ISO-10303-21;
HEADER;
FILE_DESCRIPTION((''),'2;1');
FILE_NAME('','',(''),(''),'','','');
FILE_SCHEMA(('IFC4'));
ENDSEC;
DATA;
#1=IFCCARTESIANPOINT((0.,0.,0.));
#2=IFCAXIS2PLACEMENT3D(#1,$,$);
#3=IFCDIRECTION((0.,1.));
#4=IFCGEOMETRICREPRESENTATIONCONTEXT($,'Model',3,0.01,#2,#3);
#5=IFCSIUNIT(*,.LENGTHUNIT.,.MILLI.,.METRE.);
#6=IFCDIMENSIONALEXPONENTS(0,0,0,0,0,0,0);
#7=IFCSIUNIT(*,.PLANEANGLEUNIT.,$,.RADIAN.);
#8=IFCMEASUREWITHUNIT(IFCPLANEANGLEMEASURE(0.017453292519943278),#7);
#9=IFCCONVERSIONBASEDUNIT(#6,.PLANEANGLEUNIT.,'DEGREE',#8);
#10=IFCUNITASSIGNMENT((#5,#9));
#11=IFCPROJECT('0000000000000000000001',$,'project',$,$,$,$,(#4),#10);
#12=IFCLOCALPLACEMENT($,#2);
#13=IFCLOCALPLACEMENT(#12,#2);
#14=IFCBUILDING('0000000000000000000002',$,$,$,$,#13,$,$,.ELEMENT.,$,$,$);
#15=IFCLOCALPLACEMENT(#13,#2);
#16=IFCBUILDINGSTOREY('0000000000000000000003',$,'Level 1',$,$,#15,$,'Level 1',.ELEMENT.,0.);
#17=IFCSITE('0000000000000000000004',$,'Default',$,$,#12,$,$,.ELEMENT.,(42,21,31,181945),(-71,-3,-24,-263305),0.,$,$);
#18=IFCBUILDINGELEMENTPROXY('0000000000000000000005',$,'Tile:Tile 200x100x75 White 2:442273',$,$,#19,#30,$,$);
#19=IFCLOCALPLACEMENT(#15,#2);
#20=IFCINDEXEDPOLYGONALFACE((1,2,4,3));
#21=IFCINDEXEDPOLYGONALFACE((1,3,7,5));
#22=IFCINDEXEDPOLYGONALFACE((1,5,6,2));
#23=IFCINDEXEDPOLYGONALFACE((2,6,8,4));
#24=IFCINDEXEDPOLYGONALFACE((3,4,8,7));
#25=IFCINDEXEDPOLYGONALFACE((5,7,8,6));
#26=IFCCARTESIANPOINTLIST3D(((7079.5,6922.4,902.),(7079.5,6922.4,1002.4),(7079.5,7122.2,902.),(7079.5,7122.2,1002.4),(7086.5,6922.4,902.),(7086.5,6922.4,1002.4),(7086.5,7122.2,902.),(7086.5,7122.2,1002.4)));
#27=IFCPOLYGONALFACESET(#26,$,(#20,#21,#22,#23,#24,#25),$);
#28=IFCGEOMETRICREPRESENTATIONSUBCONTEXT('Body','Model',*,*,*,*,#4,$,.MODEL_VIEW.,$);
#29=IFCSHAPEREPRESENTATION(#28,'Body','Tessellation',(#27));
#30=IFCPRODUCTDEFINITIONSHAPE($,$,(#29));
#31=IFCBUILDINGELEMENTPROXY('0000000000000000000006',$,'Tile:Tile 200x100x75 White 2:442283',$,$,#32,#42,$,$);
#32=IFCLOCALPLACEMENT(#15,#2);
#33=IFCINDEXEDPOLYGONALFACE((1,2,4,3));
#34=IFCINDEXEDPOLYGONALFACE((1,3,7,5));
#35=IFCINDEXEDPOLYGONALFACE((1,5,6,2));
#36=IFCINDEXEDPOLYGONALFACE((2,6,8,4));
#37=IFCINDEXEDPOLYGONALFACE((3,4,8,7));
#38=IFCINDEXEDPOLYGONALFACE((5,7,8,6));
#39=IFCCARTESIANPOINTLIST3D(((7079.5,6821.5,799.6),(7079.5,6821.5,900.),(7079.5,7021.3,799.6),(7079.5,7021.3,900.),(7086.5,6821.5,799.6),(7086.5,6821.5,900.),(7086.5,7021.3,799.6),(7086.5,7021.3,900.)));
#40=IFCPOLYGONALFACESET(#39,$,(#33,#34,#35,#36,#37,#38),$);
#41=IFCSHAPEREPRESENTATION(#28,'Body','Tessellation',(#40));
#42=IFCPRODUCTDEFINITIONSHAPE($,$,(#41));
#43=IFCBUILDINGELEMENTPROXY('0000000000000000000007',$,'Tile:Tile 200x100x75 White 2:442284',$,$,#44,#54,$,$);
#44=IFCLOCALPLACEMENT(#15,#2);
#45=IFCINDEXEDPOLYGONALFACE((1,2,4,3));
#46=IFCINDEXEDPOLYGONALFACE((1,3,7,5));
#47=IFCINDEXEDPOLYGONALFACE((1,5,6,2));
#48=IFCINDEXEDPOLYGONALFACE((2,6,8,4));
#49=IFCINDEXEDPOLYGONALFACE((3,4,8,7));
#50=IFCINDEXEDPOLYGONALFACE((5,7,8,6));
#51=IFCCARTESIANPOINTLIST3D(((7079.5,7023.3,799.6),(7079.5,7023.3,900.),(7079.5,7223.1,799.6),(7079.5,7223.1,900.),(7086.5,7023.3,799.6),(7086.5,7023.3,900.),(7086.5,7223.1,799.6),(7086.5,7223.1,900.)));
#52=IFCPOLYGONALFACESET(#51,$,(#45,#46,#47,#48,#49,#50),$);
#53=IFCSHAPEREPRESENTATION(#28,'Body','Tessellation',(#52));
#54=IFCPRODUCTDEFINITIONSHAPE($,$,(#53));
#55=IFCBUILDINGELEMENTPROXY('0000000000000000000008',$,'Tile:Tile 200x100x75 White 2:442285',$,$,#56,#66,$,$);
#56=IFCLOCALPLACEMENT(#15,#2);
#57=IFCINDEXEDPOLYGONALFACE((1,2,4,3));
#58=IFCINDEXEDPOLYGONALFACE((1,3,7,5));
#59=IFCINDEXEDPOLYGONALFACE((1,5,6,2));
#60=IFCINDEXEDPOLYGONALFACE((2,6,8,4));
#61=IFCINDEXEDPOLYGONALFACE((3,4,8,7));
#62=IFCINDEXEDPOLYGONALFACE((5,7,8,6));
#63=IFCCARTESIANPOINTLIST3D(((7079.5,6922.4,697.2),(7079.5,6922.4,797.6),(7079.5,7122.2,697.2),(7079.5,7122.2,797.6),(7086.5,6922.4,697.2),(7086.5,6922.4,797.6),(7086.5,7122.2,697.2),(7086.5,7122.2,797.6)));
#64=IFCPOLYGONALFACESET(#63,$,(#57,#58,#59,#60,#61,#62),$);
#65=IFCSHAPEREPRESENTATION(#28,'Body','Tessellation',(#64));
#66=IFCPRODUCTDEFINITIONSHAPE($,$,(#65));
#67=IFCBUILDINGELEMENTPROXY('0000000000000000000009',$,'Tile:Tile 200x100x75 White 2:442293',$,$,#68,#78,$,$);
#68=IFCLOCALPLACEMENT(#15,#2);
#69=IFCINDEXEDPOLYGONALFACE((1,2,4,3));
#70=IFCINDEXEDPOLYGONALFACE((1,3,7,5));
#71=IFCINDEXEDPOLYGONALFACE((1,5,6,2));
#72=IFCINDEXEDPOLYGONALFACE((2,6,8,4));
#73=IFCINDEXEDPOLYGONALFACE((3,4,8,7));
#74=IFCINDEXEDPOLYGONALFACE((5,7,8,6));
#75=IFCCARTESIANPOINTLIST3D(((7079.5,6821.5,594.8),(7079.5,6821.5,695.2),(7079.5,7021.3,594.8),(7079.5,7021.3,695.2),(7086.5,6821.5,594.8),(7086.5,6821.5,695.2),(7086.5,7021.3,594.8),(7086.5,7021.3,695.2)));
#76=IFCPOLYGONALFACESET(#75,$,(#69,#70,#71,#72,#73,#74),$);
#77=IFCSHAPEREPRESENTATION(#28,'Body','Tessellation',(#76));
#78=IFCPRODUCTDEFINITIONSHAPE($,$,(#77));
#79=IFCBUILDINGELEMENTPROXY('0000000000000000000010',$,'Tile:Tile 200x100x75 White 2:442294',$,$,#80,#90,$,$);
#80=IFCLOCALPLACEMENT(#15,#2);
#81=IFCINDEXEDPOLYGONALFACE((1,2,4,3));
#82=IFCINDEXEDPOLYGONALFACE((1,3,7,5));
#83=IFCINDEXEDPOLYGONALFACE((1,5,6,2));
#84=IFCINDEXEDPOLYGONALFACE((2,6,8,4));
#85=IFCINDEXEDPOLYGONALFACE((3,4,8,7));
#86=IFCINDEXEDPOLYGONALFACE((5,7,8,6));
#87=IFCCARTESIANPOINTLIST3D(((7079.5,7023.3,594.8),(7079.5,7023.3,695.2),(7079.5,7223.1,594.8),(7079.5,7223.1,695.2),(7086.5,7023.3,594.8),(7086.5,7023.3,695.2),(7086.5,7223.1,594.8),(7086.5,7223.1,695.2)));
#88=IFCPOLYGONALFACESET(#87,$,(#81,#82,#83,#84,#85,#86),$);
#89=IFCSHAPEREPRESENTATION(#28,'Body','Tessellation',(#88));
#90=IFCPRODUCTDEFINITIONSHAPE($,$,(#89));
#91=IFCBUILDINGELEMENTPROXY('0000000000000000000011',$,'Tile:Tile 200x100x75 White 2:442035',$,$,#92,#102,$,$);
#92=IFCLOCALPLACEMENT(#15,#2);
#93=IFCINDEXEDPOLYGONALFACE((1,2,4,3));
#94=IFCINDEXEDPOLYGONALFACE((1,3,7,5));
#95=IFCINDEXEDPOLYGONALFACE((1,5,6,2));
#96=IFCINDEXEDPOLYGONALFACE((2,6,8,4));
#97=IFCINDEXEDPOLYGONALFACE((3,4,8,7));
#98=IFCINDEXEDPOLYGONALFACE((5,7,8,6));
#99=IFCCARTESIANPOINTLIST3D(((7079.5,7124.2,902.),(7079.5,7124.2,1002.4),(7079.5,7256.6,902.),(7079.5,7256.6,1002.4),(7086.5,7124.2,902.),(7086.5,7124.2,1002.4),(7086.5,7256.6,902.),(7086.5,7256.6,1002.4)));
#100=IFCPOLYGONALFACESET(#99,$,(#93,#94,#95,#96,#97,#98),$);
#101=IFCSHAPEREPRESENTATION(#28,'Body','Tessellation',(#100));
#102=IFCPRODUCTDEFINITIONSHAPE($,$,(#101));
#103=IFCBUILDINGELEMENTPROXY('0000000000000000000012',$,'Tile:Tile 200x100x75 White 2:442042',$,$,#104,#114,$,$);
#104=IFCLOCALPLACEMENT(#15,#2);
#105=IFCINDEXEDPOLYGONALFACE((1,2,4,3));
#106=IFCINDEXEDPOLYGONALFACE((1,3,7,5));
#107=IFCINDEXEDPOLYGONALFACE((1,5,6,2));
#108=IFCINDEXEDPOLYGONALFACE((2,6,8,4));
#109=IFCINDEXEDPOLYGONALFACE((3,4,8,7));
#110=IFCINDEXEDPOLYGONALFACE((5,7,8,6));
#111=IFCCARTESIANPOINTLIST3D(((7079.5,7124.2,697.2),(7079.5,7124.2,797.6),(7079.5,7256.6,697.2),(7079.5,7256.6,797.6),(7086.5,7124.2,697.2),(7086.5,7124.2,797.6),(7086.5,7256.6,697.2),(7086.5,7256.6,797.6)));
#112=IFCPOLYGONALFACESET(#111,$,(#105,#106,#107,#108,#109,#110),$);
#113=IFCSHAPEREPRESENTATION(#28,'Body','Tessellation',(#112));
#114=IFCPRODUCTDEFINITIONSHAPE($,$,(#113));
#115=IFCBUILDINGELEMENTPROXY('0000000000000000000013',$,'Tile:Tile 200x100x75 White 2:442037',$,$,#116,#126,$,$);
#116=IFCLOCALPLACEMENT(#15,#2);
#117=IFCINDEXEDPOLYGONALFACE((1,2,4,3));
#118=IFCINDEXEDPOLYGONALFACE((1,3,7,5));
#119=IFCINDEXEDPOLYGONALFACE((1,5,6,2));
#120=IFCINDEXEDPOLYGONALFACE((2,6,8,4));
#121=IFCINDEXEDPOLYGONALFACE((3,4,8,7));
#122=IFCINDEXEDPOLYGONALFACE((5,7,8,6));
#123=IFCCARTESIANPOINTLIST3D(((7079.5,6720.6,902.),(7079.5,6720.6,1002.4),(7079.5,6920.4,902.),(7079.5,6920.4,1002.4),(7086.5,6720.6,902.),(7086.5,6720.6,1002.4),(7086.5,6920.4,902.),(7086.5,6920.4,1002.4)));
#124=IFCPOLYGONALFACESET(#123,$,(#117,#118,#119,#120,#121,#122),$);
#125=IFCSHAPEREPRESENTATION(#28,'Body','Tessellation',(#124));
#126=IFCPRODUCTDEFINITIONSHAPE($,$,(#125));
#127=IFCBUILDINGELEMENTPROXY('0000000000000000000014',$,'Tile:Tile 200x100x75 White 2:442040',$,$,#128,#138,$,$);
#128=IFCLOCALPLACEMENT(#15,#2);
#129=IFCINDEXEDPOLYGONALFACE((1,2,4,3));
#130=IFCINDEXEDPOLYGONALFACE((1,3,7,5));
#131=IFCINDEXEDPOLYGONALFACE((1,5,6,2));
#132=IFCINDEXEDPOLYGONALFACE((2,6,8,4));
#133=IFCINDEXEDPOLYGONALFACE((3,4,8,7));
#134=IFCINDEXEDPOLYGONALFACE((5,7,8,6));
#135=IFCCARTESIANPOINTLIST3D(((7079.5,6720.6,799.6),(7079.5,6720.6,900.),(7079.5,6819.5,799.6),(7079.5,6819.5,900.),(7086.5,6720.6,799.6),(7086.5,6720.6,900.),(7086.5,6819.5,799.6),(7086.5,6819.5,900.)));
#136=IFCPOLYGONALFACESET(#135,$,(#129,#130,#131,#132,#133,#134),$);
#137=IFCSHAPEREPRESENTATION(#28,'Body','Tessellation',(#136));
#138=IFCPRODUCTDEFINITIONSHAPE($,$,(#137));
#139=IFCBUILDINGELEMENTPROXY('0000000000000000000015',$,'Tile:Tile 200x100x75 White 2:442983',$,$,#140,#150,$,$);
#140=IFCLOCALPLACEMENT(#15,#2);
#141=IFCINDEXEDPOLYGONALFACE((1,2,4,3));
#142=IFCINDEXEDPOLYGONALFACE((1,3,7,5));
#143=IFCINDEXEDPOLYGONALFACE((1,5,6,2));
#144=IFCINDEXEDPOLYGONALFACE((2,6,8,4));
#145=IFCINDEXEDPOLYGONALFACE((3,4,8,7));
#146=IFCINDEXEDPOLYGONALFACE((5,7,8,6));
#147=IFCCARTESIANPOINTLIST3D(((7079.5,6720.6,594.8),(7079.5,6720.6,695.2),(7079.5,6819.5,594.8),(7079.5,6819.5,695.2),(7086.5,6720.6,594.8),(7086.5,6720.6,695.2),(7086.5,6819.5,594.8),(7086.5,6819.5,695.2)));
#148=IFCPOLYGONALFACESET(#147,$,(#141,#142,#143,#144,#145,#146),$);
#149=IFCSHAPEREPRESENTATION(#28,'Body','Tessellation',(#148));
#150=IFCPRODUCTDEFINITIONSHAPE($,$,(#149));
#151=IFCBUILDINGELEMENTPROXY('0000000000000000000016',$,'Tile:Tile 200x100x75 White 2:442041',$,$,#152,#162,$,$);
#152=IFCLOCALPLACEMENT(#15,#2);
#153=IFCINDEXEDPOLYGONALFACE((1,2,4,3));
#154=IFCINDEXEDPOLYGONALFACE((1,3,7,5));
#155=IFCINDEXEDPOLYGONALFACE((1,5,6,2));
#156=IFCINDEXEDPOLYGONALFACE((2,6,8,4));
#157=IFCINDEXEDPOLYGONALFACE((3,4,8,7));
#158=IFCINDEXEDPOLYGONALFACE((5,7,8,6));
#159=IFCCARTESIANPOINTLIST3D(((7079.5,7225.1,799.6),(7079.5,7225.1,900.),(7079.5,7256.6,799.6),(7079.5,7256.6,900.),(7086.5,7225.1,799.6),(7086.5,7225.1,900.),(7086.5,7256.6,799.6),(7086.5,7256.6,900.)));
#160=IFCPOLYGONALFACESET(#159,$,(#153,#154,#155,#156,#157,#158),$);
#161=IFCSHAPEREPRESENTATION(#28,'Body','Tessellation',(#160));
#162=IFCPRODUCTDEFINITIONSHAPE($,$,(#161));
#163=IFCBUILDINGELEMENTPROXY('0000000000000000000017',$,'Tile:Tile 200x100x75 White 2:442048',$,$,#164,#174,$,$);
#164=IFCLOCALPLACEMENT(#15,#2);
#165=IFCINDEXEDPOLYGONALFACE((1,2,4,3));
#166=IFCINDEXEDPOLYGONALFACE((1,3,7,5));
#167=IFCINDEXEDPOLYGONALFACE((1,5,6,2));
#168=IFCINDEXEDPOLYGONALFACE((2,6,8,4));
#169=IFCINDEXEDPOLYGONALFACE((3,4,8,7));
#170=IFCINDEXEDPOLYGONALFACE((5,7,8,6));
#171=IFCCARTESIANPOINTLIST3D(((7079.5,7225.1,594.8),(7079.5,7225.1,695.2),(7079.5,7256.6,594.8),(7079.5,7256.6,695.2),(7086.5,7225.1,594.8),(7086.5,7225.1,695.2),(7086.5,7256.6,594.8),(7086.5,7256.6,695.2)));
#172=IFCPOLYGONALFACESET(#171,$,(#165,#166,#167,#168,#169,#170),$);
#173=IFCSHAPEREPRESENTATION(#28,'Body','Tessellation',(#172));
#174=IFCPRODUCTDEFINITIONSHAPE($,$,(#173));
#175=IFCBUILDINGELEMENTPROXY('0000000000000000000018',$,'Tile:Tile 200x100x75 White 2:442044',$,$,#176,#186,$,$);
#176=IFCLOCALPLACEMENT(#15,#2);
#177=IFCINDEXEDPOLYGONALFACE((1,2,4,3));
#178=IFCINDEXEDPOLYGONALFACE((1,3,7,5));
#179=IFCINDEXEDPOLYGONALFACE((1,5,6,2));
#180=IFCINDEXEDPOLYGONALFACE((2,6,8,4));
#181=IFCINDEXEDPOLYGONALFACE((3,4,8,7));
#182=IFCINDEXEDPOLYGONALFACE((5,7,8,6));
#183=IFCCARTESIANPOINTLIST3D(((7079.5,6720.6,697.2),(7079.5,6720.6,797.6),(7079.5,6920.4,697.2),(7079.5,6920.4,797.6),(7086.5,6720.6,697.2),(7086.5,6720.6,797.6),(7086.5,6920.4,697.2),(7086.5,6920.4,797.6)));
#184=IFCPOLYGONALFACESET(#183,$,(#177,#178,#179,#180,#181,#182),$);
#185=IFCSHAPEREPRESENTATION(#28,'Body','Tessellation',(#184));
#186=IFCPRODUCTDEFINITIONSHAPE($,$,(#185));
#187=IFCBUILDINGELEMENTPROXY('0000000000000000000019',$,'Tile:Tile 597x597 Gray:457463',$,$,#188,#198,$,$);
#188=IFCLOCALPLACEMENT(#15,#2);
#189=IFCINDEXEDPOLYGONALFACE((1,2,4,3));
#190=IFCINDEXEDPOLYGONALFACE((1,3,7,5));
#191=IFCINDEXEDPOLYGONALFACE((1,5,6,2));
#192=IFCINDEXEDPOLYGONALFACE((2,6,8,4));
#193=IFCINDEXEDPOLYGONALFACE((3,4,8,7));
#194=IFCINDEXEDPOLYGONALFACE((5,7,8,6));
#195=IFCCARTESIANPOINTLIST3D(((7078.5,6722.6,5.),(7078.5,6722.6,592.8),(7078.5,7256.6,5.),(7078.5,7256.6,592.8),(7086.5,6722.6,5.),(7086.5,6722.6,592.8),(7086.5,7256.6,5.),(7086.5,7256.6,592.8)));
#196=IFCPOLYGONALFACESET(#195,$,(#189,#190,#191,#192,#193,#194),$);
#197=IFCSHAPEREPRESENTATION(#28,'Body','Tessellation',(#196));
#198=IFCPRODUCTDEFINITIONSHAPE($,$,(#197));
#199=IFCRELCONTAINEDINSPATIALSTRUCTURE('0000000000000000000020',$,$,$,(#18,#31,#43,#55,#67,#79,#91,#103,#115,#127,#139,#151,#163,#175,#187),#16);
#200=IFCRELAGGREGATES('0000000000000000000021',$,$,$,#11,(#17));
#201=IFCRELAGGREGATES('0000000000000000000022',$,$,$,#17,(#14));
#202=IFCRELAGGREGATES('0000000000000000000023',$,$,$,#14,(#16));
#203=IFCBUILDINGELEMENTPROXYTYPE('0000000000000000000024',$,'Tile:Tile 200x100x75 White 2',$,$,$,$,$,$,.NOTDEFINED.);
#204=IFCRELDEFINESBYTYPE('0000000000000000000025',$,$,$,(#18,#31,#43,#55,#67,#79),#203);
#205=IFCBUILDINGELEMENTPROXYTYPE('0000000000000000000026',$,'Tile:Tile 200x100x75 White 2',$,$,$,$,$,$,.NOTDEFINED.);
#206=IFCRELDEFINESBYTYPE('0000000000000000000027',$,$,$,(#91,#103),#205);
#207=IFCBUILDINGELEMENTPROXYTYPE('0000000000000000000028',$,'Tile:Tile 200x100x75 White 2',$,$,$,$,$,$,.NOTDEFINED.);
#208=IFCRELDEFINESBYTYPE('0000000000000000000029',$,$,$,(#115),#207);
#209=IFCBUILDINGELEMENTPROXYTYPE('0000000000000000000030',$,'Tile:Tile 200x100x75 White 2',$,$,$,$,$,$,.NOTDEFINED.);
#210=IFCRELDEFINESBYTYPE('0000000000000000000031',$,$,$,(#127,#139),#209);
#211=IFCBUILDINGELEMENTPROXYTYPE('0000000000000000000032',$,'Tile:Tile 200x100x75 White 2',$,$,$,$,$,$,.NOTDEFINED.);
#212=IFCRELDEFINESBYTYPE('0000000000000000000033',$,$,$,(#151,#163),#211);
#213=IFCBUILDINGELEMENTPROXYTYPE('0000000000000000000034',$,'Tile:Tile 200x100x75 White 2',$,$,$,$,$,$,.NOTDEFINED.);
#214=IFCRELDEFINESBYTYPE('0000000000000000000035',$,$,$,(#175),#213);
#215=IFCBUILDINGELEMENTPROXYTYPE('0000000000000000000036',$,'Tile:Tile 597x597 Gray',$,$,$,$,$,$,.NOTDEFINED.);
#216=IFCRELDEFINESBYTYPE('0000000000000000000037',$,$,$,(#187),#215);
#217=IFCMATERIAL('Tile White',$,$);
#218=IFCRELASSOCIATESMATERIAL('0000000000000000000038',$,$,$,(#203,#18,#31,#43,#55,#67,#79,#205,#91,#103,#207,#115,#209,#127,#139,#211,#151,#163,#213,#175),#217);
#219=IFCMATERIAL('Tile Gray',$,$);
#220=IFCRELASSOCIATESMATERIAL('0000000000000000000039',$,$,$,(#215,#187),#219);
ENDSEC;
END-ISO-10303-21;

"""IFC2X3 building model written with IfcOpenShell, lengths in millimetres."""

from ifc_helpers import new_model, entity, si_unit, converted_unit, direction, frame, frame_2d, origin, origin_2d_with_axis, place, context, subcontext, project, spatial, rectangle, extrude, source, transform, mapped, material, type_object, type_shapes, element, save


model = new_model("IFC2X3")

# Units and contexts
model_context = context("Model", 3, precision=0.01, world=origin(), true_north=direction((0.0, 1.0)))
body_context = subcontext(model_context, "Body", "Model", "MODEL_VIEW")
ifc_project = project(units=[si_unit("LENGTHUNIT", "METRE", prefix="MILLI"), converted_unit("PLANEANGLEUNIT", "DEGREE", entity("IfcPlaneAngleMeasure", 0.017453292519943278), si_unit("PLANEANGLEUNIT", "RADIAN"), dimensions=[0, 0, 0, 0, 0, 0, 0])], contexts=[model_context])

# Site, building, storey
site_placement = place(None, origin())
site = spatial("IfcSite", under=ifc_project, at=site_placement, Name="Default", CompositionType="ELEMENT", RefLatitude=(42, 21, 31, 181945), RefLongitude=(-71, -3, -24, -263305), RefElevation=0.0)
building_placement = place(site_placement, origin())
building = spatial("IfcBuilding", under=site, at=building_placement, CompositionType="ELEMENT")
storey_placement = place(building_placement, origin())
storey = spatial("IfcBuildingStorey", under=building, at=storey_placement, Name="Level 1", LongName="Level 1", CompositionType="ELEMENT", Elevation=0.0)

# Building element proxies
ifc_material_1 = material(Name="Tile White")
building_element_proxy_type_1 = type_object("IfcBuildingElementProxyType", Name="Tile:Tile 200x100x75 White 2", PredefinedType="NOTDEFINED", material=ifc_material_1)
shared_shape_1 = source(origin(), body_context, "Body", "SweptSolid", [
    extrude(rectangle(XDim=199.8, YDim=100.4, at=frame_2d((0.0, 0.0), x_axis=(1.0, 0.0))), frame((-50.2, -99.9, 0.0), z_axis=(0.0, 0.0, 1.0), x_axis=(0.0, -1.0, 0.0)), (0.0, 0.0, 1.0), 7.0),
])
type_shapes(building_element_proxy_type_1, [shared_shape_1])
for number, where, z_axis, x_axis, name in (
    (1, (7086.5, 7122.2, 1002.4), (-1.0, 0.0, 0.0), (0.0, 0.0, 1.0), "Tile:Tile 200x100x75 White 2:442273"),
    (2, (7086.5, 7021.3, 900.0), (-1.0, 0.0, 0.0), (0.0, 0.0, 1.0), "Tile:Tile 200x100x75 White 2:442283"),
    (3, (7086.5, 7223.1, 900.0), (-1.0, 0.0, 0.0), (0.0, 0.0, 1.0), "Tile:Tile 200x100x75 White 2:442284"),
    (4, (7086.5, 7122.2, 797.6), (-1.0, 0.0, 0.0), (0.0, 0.0, 1.0), "Tile:Tile 200x100x75 White 2:442285"),
    (5, (7086.5, 7021.3, 695.2), (-1.0, 0.0, 0.0), (0.0, 0.0, 1.0), "Tile:Tile 200x100x75 White 2:442293"),
    (6, (7086.5, 7223.1, 695.2), (-1.0, 0.0, 0.0), (0.0, 0.0, 1.0), "Tile:Tile 200x100x75 White 2:442294"),
):
    element("IfcBuildingElementProxy", number, at=place(storey_placement, frame(where, z_axis=z_axis, x_axis=x_axis)), inside=storey, type_object=building_element_proxy_type_1, material=ifc_material_1, Name=name, context=body_context, shape_type="MappedRepresentation", body=[
        mapped(shared_shape_1, transform((0.0, 0.0, 0.0), scale=1.0)),
    ])
building_element_proxy_type_2 = type_object("IfcBuildingElementProxyType", Name="Tile:Tile 200x100x75 White 2", PredefinedType="NOTDEFINED", material=ifc_material_1)
shared_shape_2 = source(origin(), body_context, "Body", "SweptSolid", [
    extrude(rectangle(XDim=100.4, YDim=132.4, at=frame_2d((0.0, 0.0), x_axis=(1.0, 0.0))), frame((-50.2, 66.2, 0.0)), (0.0, 0.0, 1.0), 7.0),
])
type_shapes(building_element_proxy_type_2, [shared_shape_2])
for number, where, z_axis, x_axis, name in (
    (7, (7086.5, 7124.2, 1002.4), (-1.0, 0.0, 0.0), (0.0, 0.0, 1.0), "Tile:Tile 200x100x75 White 2:442035"),
    (8, (7086.5, 7124.2, 797.6), (-1.0, 0.0, 0.0), (0.0, 0.0, 1.0), "Tile:Tile 200x100x75 White 2:442042"),
):
    element("IfcBuildingElementProxy", number, at=place(storey_placement, frame(where, z_axis=z_axis, x_axis=x_axis)), inside=storey, type_object=building_element_proxy_type_2, material=ifc_material_1, Name=name, context=body_context, shape_type="MappedRepresentation", body=[
        mapped(shared_shape_2, transform((0.0, 0.0, 0.0), scale=1.0)),
    ])
building_element_proxy_type_3 = type_object("IfcBuildingElementProxyType", Name="Tile:Tile 200x100x75 White 2", PredefinedType="NOTDEFINED", material=ifc_material_1)
shared_shape_3 = source(origin(), body_context, "Body", "SweptSolid", [
    extrude(rectangle(XDim=100.4, YDim=199.8, at=origin_2d_with_axis()), frame((-50.2, 99.9, 0.0)), (0.0, 0.0, 1.0), 7.0),
])
type_shapes(building_element_proxy_type_3, [shared_shape_3])
proxy_1_placement = place(storey_placement, frame((7086.5, 6720.6, 1002.4), z_axis=(-1.0, 0.0, 0.0), x_axis=(0.0, 0.0, 1.0)))
element("IfcBuildingElementProxy", 9, at=proxy_1_placement, inside=storey, type_object=building_element_proxy_type_3, material=ifc_material_1, Name="Tile:Tile 200x100x75 White 2:442037", context=body_context, shape_type="MappedRepresentation", body=[
    mapped(shared_shape_3, transform((0.0, 0.0, 0.0), scale=1.0)),
])
building_element_proxy_type_4 = type_object("IfcBuildingElementProxyType", Name="Tile:Tile 200x100x75 White 2", PredefinedType="NOTDEFINED", material=ifc_material_1)
shared_shape_4 = source(origin(), body_context, "Body", "SweptSolid", [
    extrude(rectangle(XDim=100.4, YDim=98.9, at=origin_2d_with_axis()), frame((-50.2, 49.5, 0.0)), (0.0, 0.0, 1.0), 7.0),
])
type_shapes(building_element_proxy_type_4, [shared_shape_4])
for number, where, z_axis, x_axis, name in (
    (10, (7086.5, 6720.6, 900.0), (-1.0, 0.0, 0.0), (0.0, 0.0, 1.0), "Tile:Tile 200x100x75 White 2:442040"),
    (11, (7086.5, 6720.6, 695.2), (-1.0, 0.0, 0.0), (0.0, 0.0, 1.0), "Tile:Tile 200x100x75 White 2:442983"),
):
    element("IfcBuildingElementProxy", number, at=place(storey_placement, frame(where, z_axis=z_axis, x_axis=x_axis)), inside=storey, type_object=building_element_proxy_type_4, material=ifc_material_1, Name=name, context=body_context, shape_type="MappedRepresentation", body=[
        mapped(shared_shape_4, transform((0.0, 0.0, 0.0), scale=1.0)),
    ])
building_element_proxy_type_5 = type_object("IfcBuildingElementProxyType", Name="Tile:Tile 200x100x75 White 2", PredefinedType="NOTDEFINED", material=ifc_material_1)
shared_shape_5 = source(origin(), body_context, "Body", "SweptSolid", [
    extrude(rectangle(XDim=100.4, YDim=31.5, at=origin_2d_with_axis()), frame((-50.2, 15.8, 0.0)), (0.0, 0.0, 1.0), 7.0),
])
type_shapes(building_element_proxy_type_5, [shared_shape_5])
for number, where, z_axis, x_axis, name in (
    (12, (7086.5, 7225.1, 900.0), (-1.0, 0.0, 0.0), (0.0, 0.0, 1.0), "Tile:Tile 200x100x75 White 2:442041"),
    (13, (7086.5, 7225.1, 695.2), (-1.0, 0.0, 0.0), (0.0, 0.0, 1.0), "Tile:Tile 200x100x75 White 2:442048"),
):
    element("IfcBuildingElementProxy", number, at=place(storey_placement, frame(where, z_axis=z_axis, x_axis=x_axis)), inside=storey, type_object=building_element_proxy_type_5, material=ifc_material_1, Name=name, context=body_context, shape_type="MappedRepresentation", body=[
        mapped(shared_shape_5, transform((0.0, 0.0, 0.0), scale=1.0)),
    ])
building_element_proxy_type_6 = type_object("IfcBuildingElementProxyType", Name="Tile:Tile 200x100x75 White 2", PredefinedType="NOTDEFINED", material=ifc_material_1)
shared_shape_6 = source(origin(), body_context, "Body", "SweptSolid", [
    extrude(rectangle(XDim=100.4, YDim=199.8, at=origin_2d_with_axis()), frame((-50.2, 99.9, 0.0)), (0.0, 0.0, 1.0), 7.0),
])
type_shapes(building_element_proxy_type_6, [shared_shape_6])
proxy_2_placement = place(storey_placement, frame((7086.5, 6720.6, 797.6), z_axis=(-1.0, 0.0, 0.0), x_axis=(0.0, 0.0, 1.0)))
element("IfcBuildingElementProxy", 14, at=proxy_2_placement, inside=storey, type_object=building_element_proxy_type_6, material=ifc_material_1, Name="Tile:Tile 200x100x75 White 2:442044", context=body_context, shape_type="MappedRepresentation", body=[
    mapped(shared_shape_6, transform((0.0, 0.0, 0.0), scale=1.0)),
])
ifc_material_2 = material(Name="Tile Gray")
building_element_proxy_type_7 = type_object("IfcBuildingElementProxyType", Name="Tile:Tile 597x597 Gray", PredefinedType="NOTDEFINED", material=ifc_material_2)
shared_shape_7 = source(origin(), body_context, "Body", "SweptSolid", [
    extrude(rectangle(XDim=534.0, YDim=587.8, at=frame_2d((0.0, 0.0), x_axis=(1.0, 0.0))), frame((-267.0, -293.9, 0.0), z_axis=(0.0, 0.0, 1.0), x_axis=(-1.0, 0.0, 0.0)), (0.0, 0.0, 1.0), 8.0),
])
type_shapes(building_element_proxy_type_7, [shared_shape_7])
proxy_3_placement = place(storey_placement, frame((7086.5, 6722.6, 592.8), z_axis=(-1.0, 0.0, 0.0), x_axis=(0.0, -1.0, 0.0)))
element("IfcBuildingElementProxy", 15, at=proxy_3_placement, inside=storey, type_object=building_element_proxy_type_7, material=ifc_material_2, Name="Tile:Tile 597x597 Gray:457463", context=body_context, shape_type="MappedRepresentation", body=[
    mapped(shared_shape_7, transform((0.0, 0.0, 0.0), scale=1.0)),
])

save(model, "model.ifc")
